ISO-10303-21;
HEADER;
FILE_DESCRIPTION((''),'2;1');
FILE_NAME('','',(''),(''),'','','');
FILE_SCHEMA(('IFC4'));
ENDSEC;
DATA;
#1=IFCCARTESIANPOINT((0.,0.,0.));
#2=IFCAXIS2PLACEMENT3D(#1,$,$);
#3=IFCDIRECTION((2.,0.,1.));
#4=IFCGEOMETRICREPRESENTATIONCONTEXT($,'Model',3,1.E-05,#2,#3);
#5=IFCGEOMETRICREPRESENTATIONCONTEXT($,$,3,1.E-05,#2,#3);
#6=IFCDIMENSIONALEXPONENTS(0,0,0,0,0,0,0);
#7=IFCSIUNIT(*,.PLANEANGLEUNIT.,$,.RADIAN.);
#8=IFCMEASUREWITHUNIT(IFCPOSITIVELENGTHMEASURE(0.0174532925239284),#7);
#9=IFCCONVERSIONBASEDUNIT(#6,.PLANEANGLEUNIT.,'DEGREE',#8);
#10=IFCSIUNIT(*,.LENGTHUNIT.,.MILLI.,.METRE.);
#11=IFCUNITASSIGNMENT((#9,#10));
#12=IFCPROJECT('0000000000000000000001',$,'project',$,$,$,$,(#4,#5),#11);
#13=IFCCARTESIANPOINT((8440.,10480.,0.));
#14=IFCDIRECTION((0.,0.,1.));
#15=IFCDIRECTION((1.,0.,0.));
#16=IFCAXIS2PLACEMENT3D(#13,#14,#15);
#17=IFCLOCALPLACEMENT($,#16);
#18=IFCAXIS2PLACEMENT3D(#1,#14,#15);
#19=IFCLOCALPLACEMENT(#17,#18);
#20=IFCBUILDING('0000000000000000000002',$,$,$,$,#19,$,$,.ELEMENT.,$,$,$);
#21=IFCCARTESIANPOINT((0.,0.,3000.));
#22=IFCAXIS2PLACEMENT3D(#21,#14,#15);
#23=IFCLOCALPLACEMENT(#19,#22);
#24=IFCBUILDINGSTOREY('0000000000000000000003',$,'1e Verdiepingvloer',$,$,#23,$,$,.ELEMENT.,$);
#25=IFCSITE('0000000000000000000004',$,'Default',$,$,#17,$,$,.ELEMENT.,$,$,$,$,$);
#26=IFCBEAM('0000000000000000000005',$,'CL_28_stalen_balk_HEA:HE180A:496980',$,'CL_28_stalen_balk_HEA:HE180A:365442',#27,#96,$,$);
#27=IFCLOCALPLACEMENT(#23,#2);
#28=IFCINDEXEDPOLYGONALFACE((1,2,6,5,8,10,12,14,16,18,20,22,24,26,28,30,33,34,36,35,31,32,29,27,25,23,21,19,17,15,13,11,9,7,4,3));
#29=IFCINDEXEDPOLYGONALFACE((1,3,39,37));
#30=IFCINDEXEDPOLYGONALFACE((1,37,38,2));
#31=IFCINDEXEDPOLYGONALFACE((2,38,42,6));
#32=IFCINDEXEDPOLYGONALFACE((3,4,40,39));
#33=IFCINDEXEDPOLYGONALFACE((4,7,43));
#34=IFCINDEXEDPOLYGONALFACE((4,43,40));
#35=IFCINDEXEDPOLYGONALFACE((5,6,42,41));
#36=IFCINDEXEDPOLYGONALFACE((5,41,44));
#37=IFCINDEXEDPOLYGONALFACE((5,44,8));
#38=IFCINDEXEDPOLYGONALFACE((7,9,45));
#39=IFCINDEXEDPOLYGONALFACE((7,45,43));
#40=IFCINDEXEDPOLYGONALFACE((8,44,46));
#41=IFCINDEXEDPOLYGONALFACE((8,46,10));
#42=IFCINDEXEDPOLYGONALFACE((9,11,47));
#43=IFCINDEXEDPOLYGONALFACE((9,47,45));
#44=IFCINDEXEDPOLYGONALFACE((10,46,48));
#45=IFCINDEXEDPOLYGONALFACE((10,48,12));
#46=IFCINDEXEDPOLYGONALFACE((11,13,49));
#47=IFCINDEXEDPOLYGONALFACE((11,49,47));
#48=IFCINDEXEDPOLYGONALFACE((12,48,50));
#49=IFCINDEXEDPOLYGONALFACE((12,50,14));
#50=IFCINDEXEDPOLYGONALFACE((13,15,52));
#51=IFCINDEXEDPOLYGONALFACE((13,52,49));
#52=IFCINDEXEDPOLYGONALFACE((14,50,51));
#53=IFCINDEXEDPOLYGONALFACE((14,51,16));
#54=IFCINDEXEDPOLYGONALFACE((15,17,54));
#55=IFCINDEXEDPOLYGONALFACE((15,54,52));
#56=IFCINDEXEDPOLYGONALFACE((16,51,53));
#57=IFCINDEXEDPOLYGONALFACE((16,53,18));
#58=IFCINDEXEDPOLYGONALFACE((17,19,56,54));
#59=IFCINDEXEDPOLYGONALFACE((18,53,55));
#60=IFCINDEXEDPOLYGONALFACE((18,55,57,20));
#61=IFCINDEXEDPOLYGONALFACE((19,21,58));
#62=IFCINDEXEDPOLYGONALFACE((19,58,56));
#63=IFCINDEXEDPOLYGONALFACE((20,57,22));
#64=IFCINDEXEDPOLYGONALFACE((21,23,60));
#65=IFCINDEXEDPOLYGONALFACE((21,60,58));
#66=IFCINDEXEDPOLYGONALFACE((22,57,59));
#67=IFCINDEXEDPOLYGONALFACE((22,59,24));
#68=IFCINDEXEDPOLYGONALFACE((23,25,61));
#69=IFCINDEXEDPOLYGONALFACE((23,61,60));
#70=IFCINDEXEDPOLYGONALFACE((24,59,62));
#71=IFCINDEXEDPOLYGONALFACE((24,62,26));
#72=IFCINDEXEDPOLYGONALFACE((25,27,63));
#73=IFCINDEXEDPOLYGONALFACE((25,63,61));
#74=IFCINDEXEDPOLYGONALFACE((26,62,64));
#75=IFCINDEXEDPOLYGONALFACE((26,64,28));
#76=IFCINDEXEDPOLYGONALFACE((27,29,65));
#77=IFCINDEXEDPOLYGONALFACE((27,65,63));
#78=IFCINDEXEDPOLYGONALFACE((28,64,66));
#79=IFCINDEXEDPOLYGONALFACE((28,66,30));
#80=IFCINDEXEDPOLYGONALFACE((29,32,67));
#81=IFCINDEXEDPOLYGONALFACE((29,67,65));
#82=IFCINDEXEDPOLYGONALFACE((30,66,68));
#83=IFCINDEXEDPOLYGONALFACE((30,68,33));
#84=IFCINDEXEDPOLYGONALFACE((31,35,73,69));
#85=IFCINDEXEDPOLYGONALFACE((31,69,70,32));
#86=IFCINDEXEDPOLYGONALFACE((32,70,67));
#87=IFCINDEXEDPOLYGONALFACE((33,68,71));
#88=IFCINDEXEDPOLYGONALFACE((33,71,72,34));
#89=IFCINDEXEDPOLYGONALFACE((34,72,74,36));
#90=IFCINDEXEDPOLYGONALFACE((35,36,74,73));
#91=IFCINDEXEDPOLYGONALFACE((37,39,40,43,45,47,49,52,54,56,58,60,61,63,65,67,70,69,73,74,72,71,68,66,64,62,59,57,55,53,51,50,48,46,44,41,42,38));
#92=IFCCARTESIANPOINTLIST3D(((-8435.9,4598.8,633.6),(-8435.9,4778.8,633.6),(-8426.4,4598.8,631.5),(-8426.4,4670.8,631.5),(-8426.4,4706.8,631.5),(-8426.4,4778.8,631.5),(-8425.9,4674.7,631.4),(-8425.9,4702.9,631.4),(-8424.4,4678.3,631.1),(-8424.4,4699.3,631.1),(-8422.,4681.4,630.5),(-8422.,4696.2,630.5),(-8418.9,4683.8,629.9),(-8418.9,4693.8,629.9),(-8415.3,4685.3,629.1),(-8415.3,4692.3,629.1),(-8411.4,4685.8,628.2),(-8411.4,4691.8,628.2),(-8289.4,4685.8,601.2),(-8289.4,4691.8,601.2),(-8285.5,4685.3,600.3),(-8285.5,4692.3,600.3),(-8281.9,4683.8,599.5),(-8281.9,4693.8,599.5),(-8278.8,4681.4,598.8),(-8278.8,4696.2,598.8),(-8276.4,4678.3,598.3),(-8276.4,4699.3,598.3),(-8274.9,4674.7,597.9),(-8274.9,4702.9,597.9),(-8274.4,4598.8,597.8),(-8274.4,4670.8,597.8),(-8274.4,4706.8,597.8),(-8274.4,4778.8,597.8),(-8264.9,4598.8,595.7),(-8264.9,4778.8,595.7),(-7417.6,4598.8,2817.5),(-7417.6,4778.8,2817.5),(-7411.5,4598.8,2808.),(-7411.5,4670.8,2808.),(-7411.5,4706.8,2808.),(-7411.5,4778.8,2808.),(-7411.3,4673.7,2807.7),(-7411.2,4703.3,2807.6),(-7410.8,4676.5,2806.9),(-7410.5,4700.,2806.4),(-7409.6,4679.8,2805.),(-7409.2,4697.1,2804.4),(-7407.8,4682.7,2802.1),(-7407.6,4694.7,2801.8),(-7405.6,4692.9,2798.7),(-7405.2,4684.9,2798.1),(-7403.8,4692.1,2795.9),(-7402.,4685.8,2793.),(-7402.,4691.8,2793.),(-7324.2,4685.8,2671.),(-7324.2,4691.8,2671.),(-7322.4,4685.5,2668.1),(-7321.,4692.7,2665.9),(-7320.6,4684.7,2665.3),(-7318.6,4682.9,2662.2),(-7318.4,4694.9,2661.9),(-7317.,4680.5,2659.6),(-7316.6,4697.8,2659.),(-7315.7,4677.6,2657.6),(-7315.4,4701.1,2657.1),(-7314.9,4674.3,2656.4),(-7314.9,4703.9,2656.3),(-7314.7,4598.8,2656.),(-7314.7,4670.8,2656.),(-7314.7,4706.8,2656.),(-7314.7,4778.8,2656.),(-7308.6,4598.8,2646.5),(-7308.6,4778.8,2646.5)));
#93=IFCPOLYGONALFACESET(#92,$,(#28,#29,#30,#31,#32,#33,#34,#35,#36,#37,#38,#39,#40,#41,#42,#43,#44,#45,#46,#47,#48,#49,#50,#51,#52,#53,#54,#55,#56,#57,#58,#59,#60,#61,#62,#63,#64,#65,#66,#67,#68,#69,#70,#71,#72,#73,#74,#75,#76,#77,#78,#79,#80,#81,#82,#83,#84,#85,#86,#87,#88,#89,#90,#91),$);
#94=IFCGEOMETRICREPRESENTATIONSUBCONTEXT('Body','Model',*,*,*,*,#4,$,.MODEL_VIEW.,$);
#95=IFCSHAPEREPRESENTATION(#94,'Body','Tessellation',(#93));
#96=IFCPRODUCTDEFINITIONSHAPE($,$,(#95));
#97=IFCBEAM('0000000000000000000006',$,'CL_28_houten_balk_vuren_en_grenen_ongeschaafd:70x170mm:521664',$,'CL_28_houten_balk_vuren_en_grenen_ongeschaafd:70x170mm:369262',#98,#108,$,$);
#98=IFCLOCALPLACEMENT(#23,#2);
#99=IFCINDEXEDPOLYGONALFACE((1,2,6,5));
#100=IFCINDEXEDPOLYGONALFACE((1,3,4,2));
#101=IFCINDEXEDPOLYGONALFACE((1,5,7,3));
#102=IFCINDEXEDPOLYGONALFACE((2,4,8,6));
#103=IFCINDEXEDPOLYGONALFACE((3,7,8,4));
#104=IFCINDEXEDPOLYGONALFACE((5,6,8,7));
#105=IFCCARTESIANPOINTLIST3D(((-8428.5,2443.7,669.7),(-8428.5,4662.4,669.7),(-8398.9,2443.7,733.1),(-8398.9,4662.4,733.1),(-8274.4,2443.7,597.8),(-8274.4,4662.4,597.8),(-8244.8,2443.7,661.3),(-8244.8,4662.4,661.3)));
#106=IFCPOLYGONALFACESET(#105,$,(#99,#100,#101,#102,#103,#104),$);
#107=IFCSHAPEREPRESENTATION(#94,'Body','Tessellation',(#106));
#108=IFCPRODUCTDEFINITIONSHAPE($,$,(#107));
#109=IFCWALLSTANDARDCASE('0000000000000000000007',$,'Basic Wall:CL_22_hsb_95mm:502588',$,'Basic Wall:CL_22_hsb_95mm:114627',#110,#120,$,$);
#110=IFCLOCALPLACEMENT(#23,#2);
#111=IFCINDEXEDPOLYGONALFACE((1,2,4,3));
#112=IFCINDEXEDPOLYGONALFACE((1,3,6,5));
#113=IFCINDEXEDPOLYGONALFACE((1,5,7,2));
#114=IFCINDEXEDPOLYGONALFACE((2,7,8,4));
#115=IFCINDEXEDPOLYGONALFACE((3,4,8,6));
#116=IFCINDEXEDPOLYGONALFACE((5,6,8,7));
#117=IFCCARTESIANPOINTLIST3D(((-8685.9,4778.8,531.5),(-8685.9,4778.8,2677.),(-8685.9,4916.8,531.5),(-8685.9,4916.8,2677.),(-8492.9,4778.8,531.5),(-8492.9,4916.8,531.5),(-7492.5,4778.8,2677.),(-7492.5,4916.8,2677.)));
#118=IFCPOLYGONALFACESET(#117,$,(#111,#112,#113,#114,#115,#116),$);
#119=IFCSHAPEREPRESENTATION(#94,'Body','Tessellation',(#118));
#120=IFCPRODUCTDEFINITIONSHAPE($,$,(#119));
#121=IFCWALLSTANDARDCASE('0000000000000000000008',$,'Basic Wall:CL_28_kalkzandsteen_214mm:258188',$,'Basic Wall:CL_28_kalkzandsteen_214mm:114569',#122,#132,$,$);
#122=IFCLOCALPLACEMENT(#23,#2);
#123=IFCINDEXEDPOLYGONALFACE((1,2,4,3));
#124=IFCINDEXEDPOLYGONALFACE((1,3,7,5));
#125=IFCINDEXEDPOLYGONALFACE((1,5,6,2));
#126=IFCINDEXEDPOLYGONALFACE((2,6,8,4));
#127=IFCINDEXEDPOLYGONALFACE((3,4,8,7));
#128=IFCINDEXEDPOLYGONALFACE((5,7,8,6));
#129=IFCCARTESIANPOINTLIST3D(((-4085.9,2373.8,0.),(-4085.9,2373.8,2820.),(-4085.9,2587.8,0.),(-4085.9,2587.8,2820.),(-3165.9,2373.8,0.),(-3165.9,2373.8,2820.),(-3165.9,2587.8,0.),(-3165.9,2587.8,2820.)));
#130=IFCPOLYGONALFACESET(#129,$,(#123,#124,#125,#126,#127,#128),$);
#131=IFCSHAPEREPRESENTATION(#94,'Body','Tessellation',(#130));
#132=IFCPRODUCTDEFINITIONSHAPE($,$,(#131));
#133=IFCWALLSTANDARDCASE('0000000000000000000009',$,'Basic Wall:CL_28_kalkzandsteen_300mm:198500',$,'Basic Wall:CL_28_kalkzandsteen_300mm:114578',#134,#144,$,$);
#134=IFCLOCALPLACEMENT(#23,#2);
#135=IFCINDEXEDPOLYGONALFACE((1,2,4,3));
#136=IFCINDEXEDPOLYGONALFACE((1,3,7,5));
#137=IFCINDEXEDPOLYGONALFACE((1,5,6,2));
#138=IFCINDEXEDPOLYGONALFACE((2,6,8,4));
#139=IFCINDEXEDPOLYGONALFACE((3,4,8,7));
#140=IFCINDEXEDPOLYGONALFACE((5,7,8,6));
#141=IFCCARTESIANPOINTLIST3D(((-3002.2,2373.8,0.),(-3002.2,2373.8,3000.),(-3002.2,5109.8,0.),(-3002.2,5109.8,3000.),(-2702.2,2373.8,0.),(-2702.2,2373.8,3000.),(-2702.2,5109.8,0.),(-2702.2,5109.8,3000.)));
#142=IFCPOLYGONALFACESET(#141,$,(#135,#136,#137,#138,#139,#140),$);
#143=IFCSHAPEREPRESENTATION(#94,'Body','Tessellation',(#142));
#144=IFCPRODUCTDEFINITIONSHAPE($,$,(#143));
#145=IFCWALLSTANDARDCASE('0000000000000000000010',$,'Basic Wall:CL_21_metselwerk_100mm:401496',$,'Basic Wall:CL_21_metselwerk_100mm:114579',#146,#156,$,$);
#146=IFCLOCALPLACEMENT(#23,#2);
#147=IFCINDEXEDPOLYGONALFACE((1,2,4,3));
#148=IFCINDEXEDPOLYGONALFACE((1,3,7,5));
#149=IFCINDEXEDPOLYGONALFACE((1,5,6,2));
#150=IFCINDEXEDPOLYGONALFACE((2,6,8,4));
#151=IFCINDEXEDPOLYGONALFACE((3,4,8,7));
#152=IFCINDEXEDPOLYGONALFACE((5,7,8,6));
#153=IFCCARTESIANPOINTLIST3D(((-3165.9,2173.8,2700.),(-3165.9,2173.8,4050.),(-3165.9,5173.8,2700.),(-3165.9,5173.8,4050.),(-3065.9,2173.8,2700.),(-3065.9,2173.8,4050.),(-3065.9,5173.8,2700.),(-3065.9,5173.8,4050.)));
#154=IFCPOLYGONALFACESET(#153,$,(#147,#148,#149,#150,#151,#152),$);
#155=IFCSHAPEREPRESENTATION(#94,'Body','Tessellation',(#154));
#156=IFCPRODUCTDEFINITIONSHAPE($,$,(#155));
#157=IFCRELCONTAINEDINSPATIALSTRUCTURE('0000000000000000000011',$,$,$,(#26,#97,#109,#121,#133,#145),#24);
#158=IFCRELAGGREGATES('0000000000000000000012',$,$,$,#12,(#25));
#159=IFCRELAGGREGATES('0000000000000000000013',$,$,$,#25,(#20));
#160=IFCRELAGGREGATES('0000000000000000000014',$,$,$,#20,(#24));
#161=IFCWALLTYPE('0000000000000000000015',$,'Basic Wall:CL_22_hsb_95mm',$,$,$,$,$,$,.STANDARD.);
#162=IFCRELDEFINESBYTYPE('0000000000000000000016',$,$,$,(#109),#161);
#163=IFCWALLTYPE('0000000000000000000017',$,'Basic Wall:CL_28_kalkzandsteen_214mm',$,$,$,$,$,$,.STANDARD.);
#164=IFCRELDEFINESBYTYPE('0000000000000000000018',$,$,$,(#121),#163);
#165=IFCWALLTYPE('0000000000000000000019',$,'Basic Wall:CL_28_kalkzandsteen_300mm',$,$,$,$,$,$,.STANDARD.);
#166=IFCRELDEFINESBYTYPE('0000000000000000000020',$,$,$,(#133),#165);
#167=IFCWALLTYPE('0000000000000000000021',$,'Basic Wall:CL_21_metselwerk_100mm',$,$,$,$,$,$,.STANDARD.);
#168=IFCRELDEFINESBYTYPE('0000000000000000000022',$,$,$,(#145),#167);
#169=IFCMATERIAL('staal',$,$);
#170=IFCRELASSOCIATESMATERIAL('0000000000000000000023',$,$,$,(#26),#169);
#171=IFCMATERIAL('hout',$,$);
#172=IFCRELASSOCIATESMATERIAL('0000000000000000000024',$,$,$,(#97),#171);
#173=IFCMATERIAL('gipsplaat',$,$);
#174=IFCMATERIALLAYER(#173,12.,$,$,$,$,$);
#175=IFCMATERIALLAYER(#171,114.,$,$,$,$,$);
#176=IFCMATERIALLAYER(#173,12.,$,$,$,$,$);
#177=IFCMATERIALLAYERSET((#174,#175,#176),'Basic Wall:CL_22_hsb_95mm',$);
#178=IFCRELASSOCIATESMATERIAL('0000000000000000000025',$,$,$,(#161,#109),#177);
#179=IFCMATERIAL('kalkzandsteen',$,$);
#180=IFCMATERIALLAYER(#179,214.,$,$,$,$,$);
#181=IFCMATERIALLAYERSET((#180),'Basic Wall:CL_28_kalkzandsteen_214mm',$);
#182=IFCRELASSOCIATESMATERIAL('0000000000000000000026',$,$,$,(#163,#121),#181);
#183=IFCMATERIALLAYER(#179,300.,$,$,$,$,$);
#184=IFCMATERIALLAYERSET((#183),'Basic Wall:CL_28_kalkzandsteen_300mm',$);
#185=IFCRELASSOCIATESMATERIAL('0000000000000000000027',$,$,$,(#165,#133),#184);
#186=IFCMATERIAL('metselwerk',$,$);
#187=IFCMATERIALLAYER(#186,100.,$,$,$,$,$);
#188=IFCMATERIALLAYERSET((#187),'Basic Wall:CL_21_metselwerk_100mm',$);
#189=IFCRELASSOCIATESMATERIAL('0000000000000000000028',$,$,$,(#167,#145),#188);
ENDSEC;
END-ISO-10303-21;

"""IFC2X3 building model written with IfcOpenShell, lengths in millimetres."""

from ifc_helpers import new_model, entity, si_unit, converted_unit, direction, frame, frame_2d, origin, origin_with_axes, origin_2d_with_axis, place, context, subcontext, project, spatial, polyline, circle_curve, parameter, trimmed, segment, composite_curve, rectangle, outline, extrude, clip, halfspace, source, transform, mapped, material, layer, layer_set, layer_usage, type_object, element, save


model = new_model("IFC2X3")

# Units and contexts
model_context = context("Model", 3, precision=1e-05, world=origin(), true_north=direction((2.0, 0.0, 1.0)))
context_of_model = context(None, 3, precision=1e-05, world=origin(), true_north=direction((2.0, 0.0, 1.0)))
body_context = subcontext(model_context, "Body", "Model", "MODEL_VIEW")
ifc_project = project(units=[converted_unit("PLANEANGLEUNIT", "DEGREE", entity("IfcPositiveLengthMeasure", 0.0174532925239284), si_unit("PLANEANGLEUNIT", "RADIAN"), dimensions=[0, 0, 0, 0, 0, 0, 0]), si_unit("LENGTHUNIT", "METRE", prefix="MILLI")], contexts=[model_context, context_of_model])

# Site, building, storey
site_placement = place(None, frame((8440.0, 10480.0, 0.0), z_axis=(0.0, 0.0, 1.0), x_axis=(1.0, 0.0, 0.0)))
site = spatial("IfcSite", under=ifc_project, at=site_placement, Name="Default", CompositionType="ELEMENT")
building_placement = place(site_placement, origin_with_axes())
building = spatial("IfcBuilding", under=site, at=building_placement, CompositionType="ELEMENT")
storey_placement = place(building_placement, frame((0.0, 0.0, 3000.0), z_axis=(0.0, 0.0, 1.0), x_axis=(1.0, 0.0, 0.0)))
storey = spatial("IfcBuildingStorey", under=building, at=storey_placement, Name="1e Verdiepingvloer", CompositionType="ELEMENT")

# Beams
ifc_material_1 = material(Name="hout")
ifc_material_2 = material(Name="staal")
beam_1_placement = place(storey_placement, frame((-8498.2, 4688.8, 500.0), z_axis=(0.906308, 0.0, -0.422618), x_axis=(0.422618, 0.0, 0.906308)))
element("IfcBeam", 1, at=beam_1_placement, inside=storey, material=ifc_material_2, Name="CL_28_stalen_balk_HEA:HE180A:496980", ObjectType="CL_28_stalen_balk_HEA:HE180A:365442", context=body_context, shape_type="Clipping", body=[
    clip(clip(extrude(outline(composite_curve([segment(polyline([(76.0, -90.0), (85.5, -90.0)]), True, "CONTINUOUS"), segment(polyline([(85.5, -90.0), (85.5, 90.0)]), True, "CONTINUOUS"), segment(polyline([(85.5, 90.0), (76.0, 90.0)]), True, "CONTINUOUS"), segment(polyline([(76.0, 90.0), (76.0, 18.0)]), True, "CONTINUOUS"), segment(trimmed(circle_curve(frame_2d((61.0, 18.0), x_axis=(1.0, 0.0)), 15.0), [parameter(270.0)], [parameter(0.0)], True, "PARAMETER"), False, "CONTINUOUS"), segment(polyline([(61.0, 3.0), (-61.0, 3.0)]), True, "CONTINUOUS"), segment(trimmed(circle_curve(frame_2d((-61.0, 18.0), x_axis=(0.0, -1.0)), 15.0), [parameter(270.0)], [parameter(0.0)], True, "PARAMETER"), False, "CONTINUOUS"), segment(polyline([(-76.0, 18.0), (-76.0, 90.0)]), True, "CONTINUOUS"), segment(polyline([(-76.0, 90.0), (-85.5, 90.0)]), True, "CONTINUOUS"), segment(polyline([(-85.5, 90.0), (-85.5, -90.0)]), True, "CONTINUOUS"), segment(polyline([(-85.5, -90.0), (-76.0, -90.0)]), True, "CONTINUOUS"), segment(polyline([(-76.0, -90.0), (-76.0, -18.0)]), True, "CONTINUOUS"), segment(trimmed(circle_curve(frame_2d((-61.0, -18.0), x_axis=(-1.0, 0.0)), 15.0), [parameter(270.0)], [parameter(0.0)], True, "PARAMETER"), False, "CONTINUOUS"), segment(polyline([(-61.0, -3.0), (61.0, -3.0)]), True, "CONTINUOUS"), segment(trimmed(circle_curve(frame_2d((61.0, -18.0), x_axis=(0.0, 1.0)), 15.0), [parameter(270.0)], [parameter(0.0)], True, "PARAMETER"), False, "CONTINUOUS"), segment(polyline([(76.0, -18.0), (76.0, -90.0)]), True, "CONTINUOUS")], self_intersect=False)), frame((147.4, 0.0, 85.5), z_axis=(1.0, 0.0, 0.0), x_axis=(0.0, 0.0, -1.0)), (0.0, 0.0, 1.0), 2409.6), halfspace(frame((2453.6, 251.2, 162.5), z_axis=(0.843391, 0.0, 0.5373), x_axis=(-0.5373, 0.0, 0.843391)), False)), halfspace(frame((147.4, 251.2, 0.0), z_axis=(-0.976296, 0.0, 0.21644), x_axis=(0.21644, 0.0, 0.976296)), False)),
])
beam_2_placement = place(storey_placement, frame((-8413.7, 2480.8, 701.4), z_axis=(0.0, 0.0, 1.0), x_axis=(0.0, 1.0, 0.0)))
element("IfcBeam", 2, at=beam_2_placement, inside=storey, material=ifc_material_1, Name="CL_28_houten_balk_vuren_en_grenen_ongeschaafd:70x170mm:521664", ObjectType="CL_28_houten_balk_vuren_en_grenen_ongeschaafd:70x170mm:369262", context=body_context, shape_type="SweptSolid", body=[
    extrude(rectangle(XDim=70.0, YDim=170.0, at=origin_2d_with_axis()), frame((-37.1, -77.0, -35.9), z_axis=(1.0, 0.0, 0.0), x_axis=(0.0, -0.422618, 0.906308)), (0.0, 0.0, 1.0), 2218.8),
])

# Walls
ifc_material_3 = material(Name="gipsplaat")
ifc_layer_1 = layer(ifc_material_3, 12.0)
ifc_layer_2 = layer(ifc_material_1, 114.0)
ifc_layer_3 = layer(ifc_material_3, 12.0)
ifc_layer_set_1 = layer_set([ifc_layer_1, ifc_layer_2, ifc_layer_3], Name="Basic Wall:CL_22_hsb_95mm")
ifc_layer_usage_1 = layer_usage(ifc_layer_set_1, "AXIS2", "POSITIVE", -69.0)
wall_type_1 = type_object("IfcWallType", Name="Basic Wall:CL_22_hsb_95mm", PredefinedType="STANDARD", material=ifc_layer_set_1)
shared_shape_1 = source(origin(), body_context, "Body", "Clipping", [
    clip(clip(extrude(rectangle(XDim=1193.5, YDim=138.0, at=frame_2d((596.7, 0.0), x_axis=(-1.0, 0.0))), origin(), (0.0, 0.0, 1.0), 2677.0), halfspace(frame((1000.5, -69.0, 531.5), z_axis=(-0.906308, 0.0, -0.422618), x_axis=(0.0, 1.0, 0.0)), False)), halfspace(frame((1193.5, -69.0, 531.5), z_axis=(0.0, 0.0, -1.0), x_axis=(0.0, 1.0, 0.0)), False)),
])
wall_1_placement = place(storey_placement, frame((-7492.5, 4847.8, 0.0), z_axis=(0.0, 0.0, 1.0), x_axis=(-1.0, 0.0, 0.0)))
element("IfcWallStandardCase", 3, at=wall_1_placement, inside=storey, type_object=wall_type_1, material=ifc_layer_usage_1, Name="Basic Wall:CL_22_hsb_95mm:502588", ObjectType="Basic Wall:CL_22_hsb_95mm:114627", context=body_context, shape_type="MappedRepresentation", body=[
    mapped(shared_shape_1, transform((0.0, 0.0, 0.0))),
])
ifc_material_4 = material(Name="kalkzandsteen")
ifc_layer_4 = layer(ifc_material_4, 214.0)
ifc_layer_set_2 = layer_set([ifc_layer_4], Name="Basic Wall:CL_28_kalkzandsteen_214mm")
ifc_layer_usage_2 = layer_usage(ifc_layer_set_2, "AXIS2", "NEGATIVE", 107.0)
wall_type_2 = type_object("IfcWallType", Name="Basic Wall:CL_28_kalkzandsteen_214mm", PredefinedType="STANDARD", material=ifc_layer_set_2)
wall_2_placement = place(storey_placement, frame((-4085.9, 2480.8, 0.0), z_axis=(0.0, 0.0, 1.0), x_axis=(1.0, 0.0, 0.0)))
element("IfcWallStandardCase", 4, at=wall_2_placement, inside=storey, type_object=wall_type_2, material=ifc_layer_usage_2, Name="Basic Wall:CL_28_kalkzandsteen_214mm:258188", ObjectType="Basic Wall:CL_28_kalkzandsteen_214mm:114569", context=body_context, shape_type="SweptSolid", body=[
    extrude(rectangle(XDim=920.0, YDim=214.0, at=frame_2d((460.0, 0.0), x_axis=(-1.0, 0.0))), origin(), (0.0, 0.0, 1.0), 2820.0),
])
ifc_layer_5 = layer(ifc_material_4, 300.0)
ifc_layer_set_3 = layer_set([ifc_layer_5], Name="Basic Wall:CL_28_kalkzandsteen_300mm")
ifc_layer_usage_3 = layer_usage(ifc_layer_set_3, "AXIS2", "NEGATIVE", 150.0)
wall_type_3 = type_object("IfcWallType", Name="Basic Wall:CL_28_kalkzandsteen_300mm", PredefinedType="STANDARD", material=ifc_layer_set_3)
wall_3_placement = place(storey_placement, frame((-2852.2, 5109.8, 0.0), z_axis=(0.0, 0.0, 1.0), x_axis=(0.0, -1.0, 0.0)))
element("IfcWallStandardCase", 5, at=wall_3_placement, inside=storey, type_object=wall_type_3, material=ifc_layer_usage_3, Name="Basic Wall:CL_28_kalkzandsteen_300mm:198500", ObjectType="Basic Wall:CL_28_kalkzandsteen_300mm:114578", context=body_context, shape_type="SweptSolid", body=[
    extrude(rectangle(XDim=2736.0, YDim=300.0, at=frame_2d((1368.0, 0.0), x_axis=(-1.0, 0.0))), origin(), (0.0, 0.0, 1.0), 3000.0),
])
ifc_material_5 = material(Name="metselwerk")
ifc_layer_6 = layer(ifc_material_5, 100.0)
ifc_layer_set_4 = layer_set([ifc_layer_6], Name="Basic Wall:CL_21_metselwerk_100mm")
ifc_layer_usage_4 = layer_usage(ifc_layer_set_4, "AXIS2", "NEGATIVE", 50.0)
wall_type_4 = type_object("IfcWallType", Name="Basic Wall:CL_21_metselwerk_100mm", PredefinedType="STANDARD", material=ifc_layer_set_4)
wall_4_placement = place(storey_placement, frame((-3115.9, 5173.8, 2700.0), z_axis=(0.0, 0.0, 1.0), x_axis=(0.0, -1.0, 0.0)))
element("IfcWallStandardCase", 6, at=wall_4_placement, inside=storey, type_object=wall_type_4, material=ifc_layer_usage_4, Name="Basic Wall:CL_21_metselwerk_100mm:401496", ObjectType="Basic Wall:CL_21_metselwerk_100mm:114579", context=body_context, shape_type="SweptSolid", body=[
    extrude(rectangle(XDim=3000.0, YDim=100.0, at=frame_2d((1500.0, 0.0), x_axis=(-1.0, 0.0))), origin(), (0.0, 0.0, 1.0), 1350.0),
])

save(model, "model.ifc")
